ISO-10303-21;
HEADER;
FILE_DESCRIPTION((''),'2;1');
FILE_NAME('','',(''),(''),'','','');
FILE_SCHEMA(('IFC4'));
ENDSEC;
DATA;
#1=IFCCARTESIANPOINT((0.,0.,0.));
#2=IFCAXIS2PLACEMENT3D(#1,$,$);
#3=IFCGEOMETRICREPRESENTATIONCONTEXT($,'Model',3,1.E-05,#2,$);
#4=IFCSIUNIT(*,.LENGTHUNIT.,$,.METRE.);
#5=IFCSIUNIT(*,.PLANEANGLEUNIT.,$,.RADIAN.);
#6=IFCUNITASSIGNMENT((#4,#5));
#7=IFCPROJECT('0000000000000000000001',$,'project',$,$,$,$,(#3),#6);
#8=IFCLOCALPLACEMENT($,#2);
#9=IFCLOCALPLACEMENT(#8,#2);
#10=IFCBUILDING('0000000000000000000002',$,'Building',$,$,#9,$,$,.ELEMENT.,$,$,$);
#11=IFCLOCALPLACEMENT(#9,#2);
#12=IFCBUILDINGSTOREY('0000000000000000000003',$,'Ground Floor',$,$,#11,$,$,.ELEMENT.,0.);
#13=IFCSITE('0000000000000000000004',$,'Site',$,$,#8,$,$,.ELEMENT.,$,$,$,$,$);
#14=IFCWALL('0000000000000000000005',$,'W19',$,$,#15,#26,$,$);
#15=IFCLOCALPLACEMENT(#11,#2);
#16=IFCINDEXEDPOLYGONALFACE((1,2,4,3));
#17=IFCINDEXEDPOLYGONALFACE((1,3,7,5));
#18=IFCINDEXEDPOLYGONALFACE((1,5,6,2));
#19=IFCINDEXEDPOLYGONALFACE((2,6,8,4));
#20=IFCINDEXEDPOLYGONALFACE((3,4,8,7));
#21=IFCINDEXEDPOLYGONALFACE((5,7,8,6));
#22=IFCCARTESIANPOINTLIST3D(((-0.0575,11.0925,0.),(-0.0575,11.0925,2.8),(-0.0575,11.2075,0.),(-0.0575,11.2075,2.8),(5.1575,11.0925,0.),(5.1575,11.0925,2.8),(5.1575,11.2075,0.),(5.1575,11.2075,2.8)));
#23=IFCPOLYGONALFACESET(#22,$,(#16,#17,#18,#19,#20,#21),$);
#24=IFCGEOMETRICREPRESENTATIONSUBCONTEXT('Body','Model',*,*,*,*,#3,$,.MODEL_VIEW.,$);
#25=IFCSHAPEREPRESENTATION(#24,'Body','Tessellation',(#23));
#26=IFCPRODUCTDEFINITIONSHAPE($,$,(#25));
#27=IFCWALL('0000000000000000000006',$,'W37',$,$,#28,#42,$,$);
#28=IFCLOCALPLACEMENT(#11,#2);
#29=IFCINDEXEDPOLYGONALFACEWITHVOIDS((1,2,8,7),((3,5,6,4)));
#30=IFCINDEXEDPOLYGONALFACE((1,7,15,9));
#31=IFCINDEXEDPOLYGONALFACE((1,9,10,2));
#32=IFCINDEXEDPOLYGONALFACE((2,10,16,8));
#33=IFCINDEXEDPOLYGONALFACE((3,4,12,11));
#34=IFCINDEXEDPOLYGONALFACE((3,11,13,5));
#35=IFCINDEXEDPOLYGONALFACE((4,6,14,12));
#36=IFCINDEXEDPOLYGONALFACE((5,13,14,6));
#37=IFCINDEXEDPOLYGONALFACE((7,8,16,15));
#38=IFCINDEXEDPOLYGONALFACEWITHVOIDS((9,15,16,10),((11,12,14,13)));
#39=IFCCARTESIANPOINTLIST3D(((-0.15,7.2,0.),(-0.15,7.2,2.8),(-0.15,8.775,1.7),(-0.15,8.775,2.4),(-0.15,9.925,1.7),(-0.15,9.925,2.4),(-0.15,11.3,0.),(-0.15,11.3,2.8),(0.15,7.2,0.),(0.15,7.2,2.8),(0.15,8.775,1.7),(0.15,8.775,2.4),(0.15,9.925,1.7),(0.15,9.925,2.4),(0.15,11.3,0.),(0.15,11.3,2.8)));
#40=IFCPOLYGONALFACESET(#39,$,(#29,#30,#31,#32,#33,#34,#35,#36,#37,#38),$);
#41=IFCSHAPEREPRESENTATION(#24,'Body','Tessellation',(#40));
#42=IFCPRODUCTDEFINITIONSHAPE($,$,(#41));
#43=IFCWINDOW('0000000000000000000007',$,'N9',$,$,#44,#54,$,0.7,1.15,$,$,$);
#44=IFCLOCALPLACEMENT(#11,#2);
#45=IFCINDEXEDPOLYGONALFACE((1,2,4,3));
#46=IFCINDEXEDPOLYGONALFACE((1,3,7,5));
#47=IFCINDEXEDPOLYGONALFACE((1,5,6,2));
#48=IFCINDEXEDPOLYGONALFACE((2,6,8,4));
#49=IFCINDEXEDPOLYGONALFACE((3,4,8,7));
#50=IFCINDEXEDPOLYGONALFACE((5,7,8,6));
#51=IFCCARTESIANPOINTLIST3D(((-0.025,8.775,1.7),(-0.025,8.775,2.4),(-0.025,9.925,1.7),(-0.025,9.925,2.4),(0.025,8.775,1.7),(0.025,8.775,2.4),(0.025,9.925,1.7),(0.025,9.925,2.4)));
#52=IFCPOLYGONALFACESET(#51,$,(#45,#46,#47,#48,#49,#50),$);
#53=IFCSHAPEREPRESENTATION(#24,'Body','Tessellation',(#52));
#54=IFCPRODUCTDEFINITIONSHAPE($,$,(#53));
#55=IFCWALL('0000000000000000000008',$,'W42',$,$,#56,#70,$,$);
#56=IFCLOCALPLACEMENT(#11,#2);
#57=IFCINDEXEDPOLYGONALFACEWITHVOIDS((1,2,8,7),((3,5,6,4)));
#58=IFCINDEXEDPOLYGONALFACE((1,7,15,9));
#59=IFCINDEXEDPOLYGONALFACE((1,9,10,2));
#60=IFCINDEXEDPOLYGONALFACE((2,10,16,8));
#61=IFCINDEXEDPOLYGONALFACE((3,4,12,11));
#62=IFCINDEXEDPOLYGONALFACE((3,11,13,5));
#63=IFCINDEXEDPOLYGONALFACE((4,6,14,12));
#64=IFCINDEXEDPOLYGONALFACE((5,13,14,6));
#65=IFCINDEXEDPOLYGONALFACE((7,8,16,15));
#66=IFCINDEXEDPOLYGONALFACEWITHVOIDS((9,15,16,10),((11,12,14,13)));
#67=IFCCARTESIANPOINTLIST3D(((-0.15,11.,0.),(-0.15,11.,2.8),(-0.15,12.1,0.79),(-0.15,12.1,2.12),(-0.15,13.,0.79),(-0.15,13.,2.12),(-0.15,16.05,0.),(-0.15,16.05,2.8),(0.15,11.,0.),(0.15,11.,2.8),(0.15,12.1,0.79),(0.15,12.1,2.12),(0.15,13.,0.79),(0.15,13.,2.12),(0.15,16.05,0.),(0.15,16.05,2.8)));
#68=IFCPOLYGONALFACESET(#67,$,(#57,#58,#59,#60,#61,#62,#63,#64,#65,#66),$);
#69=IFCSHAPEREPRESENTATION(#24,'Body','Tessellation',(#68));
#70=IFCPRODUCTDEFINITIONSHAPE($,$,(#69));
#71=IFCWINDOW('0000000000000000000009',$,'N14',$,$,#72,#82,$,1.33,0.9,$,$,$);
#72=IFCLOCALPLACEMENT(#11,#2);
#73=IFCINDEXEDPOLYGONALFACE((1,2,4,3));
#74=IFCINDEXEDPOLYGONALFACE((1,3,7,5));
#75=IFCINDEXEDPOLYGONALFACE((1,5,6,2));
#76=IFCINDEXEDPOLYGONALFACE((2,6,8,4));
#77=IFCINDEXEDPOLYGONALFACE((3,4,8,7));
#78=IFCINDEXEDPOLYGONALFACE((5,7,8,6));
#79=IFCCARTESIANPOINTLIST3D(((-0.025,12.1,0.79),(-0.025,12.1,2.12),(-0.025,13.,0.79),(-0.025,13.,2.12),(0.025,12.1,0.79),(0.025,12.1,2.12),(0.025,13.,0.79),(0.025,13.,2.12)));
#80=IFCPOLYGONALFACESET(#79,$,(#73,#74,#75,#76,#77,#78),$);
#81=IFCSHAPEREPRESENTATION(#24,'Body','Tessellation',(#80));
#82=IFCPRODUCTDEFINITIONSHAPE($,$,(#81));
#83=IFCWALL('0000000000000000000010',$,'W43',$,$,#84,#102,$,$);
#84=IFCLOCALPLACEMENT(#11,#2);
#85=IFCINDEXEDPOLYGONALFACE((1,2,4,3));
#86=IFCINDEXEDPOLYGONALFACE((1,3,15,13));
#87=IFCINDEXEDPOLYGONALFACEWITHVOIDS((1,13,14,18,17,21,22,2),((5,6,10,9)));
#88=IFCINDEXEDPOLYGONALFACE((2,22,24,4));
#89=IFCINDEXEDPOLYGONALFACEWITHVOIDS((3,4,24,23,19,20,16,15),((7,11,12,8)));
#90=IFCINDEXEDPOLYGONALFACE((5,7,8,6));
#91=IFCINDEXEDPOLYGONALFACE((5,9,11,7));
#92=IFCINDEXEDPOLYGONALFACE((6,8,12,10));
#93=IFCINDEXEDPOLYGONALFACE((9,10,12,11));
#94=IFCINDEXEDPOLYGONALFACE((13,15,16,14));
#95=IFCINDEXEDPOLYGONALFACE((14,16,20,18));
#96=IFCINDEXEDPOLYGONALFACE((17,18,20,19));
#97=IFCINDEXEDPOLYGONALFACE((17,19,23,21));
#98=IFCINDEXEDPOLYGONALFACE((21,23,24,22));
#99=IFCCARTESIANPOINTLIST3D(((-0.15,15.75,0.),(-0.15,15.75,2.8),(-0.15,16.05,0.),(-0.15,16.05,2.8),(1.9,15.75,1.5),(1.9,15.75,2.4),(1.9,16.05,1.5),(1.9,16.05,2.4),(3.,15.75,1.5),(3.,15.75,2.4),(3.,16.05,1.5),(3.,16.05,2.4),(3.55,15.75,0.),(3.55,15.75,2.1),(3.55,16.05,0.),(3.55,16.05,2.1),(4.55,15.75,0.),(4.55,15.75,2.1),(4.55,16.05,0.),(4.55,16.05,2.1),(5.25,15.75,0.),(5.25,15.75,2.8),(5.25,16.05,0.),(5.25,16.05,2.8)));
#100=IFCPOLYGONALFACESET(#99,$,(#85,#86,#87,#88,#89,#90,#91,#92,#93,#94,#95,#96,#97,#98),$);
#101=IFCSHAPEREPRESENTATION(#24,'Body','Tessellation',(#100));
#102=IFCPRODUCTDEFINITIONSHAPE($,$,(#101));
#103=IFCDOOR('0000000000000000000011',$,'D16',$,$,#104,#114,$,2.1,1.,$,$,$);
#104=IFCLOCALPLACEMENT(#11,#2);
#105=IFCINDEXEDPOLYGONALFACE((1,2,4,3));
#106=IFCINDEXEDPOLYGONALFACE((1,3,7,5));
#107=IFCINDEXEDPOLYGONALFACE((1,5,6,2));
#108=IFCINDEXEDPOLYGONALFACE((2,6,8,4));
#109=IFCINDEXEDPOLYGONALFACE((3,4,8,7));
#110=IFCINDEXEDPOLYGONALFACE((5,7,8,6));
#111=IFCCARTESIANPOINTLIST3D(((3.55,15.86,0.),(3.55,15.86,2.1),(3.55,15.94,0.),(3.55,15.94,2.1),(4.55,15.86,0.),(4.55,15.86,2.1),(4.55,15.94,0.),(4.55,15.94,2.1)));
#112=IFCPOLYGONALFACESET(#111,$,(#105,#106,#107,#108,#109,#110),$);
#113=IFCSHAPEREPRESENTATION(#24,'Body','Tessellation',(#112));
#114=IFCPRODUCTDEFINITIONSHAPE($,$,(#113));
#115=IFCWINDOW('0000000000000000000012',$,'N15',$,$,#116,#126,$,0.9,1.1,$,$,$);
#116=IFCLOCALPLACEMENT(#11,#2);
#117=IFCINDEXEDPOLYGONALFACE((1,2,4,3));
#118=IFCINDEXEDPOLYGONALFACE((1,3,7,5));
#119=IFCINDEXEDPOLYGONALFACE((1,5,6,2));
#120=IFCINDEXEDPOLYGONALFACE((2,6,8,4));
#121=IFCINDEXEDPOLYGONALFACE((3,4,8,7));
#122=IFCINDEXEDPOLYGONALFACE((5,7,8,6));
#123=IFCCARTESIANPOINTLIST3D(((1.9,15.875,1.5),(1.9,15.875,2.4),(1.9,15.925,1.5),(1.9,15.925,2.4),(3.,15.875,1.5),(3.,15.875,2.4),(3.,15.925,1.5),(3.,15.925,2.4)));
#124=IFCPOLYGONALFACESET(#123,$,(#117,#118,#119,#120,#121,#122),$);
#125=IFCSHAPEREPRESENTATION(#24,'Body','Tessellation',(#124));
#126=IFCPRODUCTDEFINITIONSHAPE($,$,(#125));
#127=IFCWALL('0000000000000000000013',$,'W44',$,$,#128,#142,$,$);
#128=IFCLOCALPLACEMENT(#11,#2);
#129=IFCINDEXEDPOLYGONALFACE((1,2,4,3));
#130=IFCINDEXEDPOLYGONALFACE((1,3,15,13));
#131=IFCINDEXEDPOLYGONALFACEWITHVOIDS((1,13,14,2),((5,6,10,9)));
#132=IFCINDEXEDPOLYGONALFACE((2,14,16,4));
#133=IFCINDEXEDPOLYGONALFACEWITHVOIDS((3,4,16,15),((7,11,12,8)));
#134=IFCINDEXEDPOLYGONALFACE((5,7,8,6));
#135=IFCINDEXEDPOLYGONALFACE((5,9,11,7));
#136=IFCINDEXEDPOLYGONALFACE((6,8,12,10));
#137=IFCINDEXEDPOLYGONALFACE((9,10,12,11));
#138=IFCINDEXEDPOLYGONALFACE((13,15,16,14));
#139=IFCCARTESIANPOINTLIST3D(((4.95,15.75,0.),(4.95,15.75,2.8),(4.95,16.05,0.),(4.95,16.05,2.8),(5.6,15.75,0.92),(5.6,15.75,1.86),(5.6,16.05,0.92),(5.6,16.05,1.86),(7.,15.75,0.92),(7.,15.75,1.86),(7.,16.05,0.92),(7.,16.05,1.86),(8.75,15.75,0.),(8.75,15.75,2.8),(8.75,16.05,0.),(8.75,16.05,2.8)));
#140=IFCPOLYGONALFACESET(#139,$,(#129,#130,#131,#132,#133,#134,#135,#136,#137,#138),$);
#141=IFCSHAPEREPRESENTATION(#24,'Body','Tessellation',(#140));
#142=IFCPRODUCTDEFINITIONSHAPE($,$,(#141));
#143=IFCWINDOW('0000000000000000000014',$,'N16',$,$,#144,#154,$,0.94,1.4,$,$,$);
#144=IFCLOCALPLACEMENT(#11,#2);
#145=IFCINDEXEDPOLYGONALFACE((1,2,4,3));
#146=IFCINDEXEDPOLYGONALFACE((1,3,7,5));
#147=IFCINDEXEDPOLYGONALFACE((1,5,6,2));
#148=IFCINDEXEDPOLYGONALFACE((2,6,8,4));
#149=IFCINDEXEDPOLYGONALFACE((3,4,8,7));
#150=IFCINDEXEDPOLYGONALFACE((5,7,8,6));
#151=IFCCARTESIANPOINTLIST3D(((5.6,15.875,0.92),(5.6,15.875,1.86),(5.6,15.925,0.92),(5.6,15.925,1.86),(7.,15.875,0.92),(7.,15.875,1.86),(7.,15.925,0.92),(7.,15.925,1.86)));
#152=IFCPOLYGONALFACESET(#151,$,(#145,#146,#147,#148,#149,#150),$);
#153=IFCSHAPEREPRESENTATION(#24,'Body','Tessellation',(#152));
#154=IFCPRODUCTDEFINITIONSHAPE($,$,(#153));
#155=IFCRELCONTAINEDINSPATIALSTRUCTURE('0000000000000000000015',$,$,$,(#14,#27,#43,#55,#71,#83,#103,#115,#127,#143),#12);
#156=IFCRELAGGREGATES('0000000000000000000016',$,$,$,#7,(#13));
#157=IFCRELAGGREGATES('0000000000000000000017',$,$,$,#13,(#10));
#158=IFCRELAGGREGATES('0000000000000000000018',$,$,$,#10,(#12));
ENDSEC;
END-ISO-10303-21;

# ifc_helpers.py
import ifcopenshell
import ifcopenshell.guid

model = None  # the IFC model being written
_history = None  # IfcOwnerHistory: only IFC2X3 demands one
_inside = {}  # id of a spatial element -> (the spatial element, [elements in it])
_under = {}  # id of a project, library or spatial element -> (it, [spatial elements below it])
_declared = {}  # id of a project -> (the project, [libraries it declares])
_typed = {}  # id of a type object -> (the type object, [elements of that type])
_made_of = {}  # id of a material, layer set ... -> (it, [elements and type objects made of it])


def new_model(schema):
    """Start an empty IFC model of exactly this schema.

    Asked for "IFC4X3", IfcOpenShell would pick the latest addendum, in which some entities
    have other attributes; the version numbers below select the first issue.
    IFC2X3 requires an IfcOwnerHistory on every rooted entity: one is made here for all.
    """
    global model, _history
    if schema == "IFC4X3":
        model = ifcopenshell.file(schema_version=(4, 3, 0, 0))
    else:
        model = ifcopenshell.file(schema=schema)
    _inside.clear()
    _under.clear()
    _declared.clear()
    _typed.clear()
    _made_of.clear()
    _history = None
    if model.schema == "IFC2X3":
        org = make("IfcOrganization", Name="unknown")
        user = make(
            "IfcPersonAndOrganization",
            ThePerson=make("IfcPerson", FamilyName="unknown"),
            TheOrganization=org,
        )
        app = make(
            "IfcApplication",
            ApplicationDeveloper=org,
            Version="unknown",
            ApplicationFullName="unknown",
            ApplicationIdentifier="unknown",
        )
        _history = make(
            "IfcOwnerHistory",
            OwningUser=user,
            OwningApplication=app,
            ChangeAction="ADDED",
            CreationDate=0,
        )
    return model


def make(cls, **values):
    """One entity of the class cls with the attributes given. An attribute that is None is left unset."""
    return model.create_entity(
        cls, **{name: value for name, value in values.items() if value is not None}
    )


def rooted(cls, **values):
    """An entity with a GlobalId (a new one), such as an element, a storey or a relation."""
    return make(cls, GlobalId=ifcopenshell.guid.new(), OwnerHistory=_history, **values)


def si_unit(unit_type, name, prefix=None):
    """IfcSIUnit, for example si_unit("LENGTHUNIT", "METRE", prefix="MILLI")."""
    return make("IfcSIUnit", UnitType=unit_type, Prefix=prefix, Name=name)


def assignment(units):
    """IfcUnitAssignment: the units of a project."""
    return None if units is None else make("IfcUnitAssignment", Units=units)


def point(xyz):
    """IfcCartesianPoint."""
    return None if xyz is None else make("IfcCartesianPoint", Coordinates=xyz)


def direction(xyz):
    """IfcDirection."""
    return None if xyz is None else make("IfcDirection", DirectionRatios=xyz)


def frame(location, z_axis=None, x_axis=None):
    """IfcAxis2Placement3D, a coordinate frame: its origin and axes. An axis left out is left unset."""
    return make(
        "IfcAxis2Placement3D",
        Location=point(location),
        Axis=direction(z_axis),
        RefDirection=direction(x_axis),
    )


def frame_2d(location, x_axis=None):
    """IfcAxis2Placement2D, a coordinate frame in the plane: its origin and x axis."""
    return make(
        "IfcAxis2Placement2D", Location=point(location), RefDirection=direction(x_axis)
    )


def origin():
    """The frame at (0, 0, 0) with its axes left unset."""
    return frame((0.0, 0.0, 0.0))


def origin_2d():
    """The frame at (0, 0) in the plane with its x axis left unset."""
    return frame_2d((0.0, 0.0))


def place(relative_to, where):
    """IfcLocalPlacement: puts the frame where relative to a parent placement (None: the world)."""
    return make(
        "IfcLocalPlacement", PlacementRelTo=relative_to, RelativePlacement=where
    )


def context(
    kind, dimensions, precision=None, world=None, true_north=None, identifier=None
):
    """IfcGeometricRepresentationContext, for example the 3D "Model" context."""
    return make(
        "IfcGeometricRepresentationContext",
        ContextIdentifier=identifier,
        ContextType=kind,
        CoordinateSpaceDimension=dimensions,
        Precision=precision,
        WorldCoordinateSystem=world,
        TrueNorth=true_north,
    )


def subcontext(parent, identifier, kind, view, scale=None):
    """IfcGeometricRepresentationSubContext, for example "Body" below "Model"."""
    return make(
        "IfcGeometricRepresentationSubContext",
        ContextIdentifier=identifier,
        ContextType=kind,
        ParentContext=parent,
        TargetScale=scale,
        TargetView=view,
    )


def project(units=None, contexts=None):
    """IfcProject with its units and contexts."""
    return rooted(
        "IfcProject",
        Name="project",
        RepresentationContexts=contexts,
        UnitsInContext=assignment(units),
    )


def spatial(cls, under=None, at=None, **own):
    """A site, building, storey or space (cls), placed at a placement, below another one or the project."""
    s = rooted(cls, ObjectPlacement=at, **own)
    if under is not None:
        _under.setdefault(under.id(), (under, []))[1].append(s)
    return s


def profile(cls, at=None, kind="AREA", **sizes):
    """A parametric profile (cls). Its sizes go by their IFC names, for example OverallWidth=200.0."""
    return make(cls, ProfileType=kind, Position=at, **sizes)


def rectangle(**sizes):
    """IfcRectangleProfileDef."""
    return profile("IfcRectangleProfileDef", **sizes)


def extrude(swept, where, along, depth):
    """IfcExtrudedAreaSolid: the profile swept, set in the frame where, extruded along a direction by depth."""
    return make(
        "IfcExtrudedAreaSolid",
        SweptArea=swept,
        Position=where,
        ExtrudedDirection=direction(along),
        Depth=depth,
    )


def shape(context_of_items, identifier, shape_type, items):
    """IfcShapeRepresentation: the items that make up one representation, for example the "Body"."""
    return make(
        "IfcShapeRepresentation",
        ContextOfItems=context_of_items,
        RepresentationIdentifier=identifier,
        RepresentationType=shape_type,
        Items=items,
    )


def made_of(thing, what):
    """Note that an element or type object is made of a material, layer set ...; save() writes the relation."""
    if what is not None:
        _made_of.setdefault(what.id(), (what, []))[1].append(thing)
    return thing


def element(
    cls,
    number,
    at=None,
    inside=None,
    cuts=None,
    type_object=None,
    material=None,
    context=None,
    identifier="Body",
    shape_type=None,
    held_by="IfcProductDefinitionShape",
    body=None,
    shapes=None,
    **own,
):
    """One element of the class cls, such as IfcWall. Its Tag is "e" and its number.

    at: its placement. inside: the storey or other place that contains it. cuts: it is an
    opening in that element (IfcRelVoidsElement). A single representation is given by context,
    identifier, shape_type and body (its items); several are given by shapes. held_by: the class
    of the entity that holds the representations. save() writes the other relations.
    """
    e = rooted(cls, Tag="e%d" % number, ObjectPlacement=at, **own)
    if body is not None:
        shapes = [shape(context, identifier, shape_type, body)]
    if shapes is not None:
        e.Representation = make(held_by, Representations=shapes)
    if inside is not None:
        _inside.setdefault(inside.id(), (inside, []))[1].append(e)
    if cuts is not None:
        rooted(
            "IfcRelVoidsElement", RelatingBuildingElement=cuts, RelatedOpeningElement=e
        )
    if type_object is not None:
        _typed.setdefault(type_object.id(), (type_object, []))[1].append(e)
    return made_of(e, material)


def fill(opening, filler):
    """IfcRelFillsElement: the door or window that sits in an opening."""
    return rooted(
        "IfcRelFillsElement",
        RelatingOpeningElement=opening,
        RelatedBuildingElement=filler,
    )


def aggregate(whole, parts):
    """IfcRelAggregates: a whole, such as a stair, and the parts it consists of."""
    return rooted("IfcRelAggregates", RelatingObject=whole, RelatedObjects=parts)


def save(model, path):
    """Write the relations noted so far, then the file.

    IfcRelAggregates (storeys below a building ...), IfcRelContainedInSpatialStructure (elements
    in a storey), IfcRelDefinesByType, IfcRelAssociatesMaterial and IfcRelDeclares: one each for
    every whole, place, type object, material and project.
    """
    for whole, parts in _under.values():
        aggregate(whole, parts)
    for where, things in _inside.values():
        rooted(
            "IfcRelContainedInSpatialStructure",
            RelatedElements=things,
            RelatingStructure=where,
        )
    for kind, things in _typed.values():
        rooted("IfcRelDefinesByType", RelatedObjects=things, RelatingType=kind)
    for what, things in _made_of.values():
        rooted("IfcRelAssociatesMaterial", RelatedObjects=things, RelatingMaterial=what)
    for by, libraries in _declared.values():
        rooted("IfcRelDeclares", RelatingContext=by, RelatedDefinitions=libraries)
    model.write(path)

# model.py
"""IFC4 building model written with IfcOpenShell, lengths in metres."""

from ifc_helpers import new_model, si_unit, frame, frame_2d, origin, origin_2d, place, context, subcontext, project, spatial, rectangle, extrude, element, fill, save


model = new_model("IFC4")

# Units and contexts
model_context = context("Model", 3, precision=1e-05, world=origin())
body_context = subcontext(model_context, "Body", "Model", "MODEL_VIEW")
ifc_project = project(units=[si_unit("LENGTHUNIT", "METRE"), si_unit("PLANEANGLEUNIT", "RADIAN")], contexts=[model_context])

# Site, building, storey
site_placement = place(None, origin())
site = spatial("IfcSite", under=ifc_project, at=site_placement, Name="Site", CompositionType="ELEMENT")
building_placement = place(site_placement, origin())
building = spatial("IfcBuilding", under=site, at=building_placement, Name="Building", CompositionType="ELEMENT")
storey_placement = place(building_placement, origin())
storey = spatial("IfcBuildingStorey", under=building, at=storey_placement, Name="Ground Floor", CompositionType="ELEMENT", Elevation=0.0)

# Wall
wall_1_placement = place(storey_placement, frame((0.0, 11.15, 0.0), x_axis=(1.0, 0.0, 0.0)))
element("IfcWall", 1, at=wall_1_placement, inside=storey, Name="W19", context=body_context, shape_type="SweptSolid", body=[
    extrude(rectangle(XDim=5.215, YDim=0.115, at=frame_2d((2.55, 0.0))), origin(), (0.0, 0.0, 1.0), 2.8),
])

# Walls, openings, windows
wall_2_placement = place(storey_placement, frame((0.0, 7.35, 0.0), x_axis=(0.0, 1.0, 0.0)))
wall_2 = element("IfcWall", 2, at=wall_2_placement, inside=storey, Name="W37", context=body_context, shape_type="SweptSolid", body=[
    extrude(rectangle(XDim=4.1, YDim=0.3, at=frame_2d((1.9, 0.0))), origin(), (0.0, 0.0, 1.0), 2.8),
])
opening_1_placement = place(wall_2_placement, frame((2.0, 0.0, 1.7)))
opening_1 = element("IfcOpeningElement", 3, at=opening_1_placement, cuts=wall_2, context=body_context, shape_type="SweptSolid", body=[
    extrude(rectangle(XDim=1.15, YDim=0.4, at=origin_2d()), origin(), (0.0, 0.0, 1.0), 0.7),
])
window_1_placement = place(opening_1_placement, origin())
window_1 = element("IfcWindow", 4, at=window_1_placement, inside=storey, Name="N9", OverallHeight=0.7, OverallWidth=1.15, context=body_context, shape_type="SweptSolid", body=[
    extrude(rectangle(XDim=1.15, YDim=0.05, at=origin_2d()), origin(), (0.0, 0.0, 1.0), 0.7),
])
fill(opening_1, window_1)
wall_3_placement = place(storey_placement, frame((0.0, 11.15, 0.0), x_axis=(0.0, 1.0, 0.0)))
wall_3 = element("IfcWall", 5, at=wall_3_placement, inside=storey, Name="W42", context=body_context, shape_type="SweptSolid", body=[
    extrude(rectangle(XDim=5.05, YDim=0.3, at=frame_2d((2.375, 0.0))), origin(), (0.0, 0.0, 1.0), 2.8),
])
opening_2_placement = place(wall_3_placement, frame((1.4, 0.0, 0.79)))
opening_2 = element("IfcOpeningElement", 6, at=opening_2_placement, cuts=wall_3, context=body_context, shape_type="SweptSolid", body=[
    extrude(rectangle(XDim=0.9, YDim=0.4, at=origin_2d()), origin(), (0.0, 0.0, 1.0), 1.33),
])
window_2_placement = place(opening_2_placement, origin())
window_2 = element("IfcWindow", 7, at=window_2_placement, inside=storey, Name="N14", OverallHeight=1.33, OverallWidth=0.9, context=body_context, shape_type="SweptSolid", body=[
    extrude(rectangle(XDim=0.9, YDim=0.05, at=origin_2d()), origin(), (0.0, 0.0, 1.0), 1.33),
])
fill(opening_2, window_2)

# Wall, openings, door, window
wall_4_placement = place(storey_placement, frame((0.0, 15.9, 0.0), x_axis=(1.0, 0.0, 0.0)))
wall_4 = element("IfcWall", 8, at=wall_4_placement, inside=storey, Name="W43", context=body_context, shape_type="SweptSolid", body=[
    extrude(rectangle(XDim=5.4, YDim=0.3, at=frame_2d((2.55, 0.0))), origin(), (0.0, 0.0, 1.0), 2.8),
])
opening_3_placement = place(wall_4_placement, frame((4.05, 0.0, 0.0)))
opening_3 = element("IfcOpeningElement", 9, at=opening_3_placement, cuts=wall_4, context=body_context, shape_type="SweptSolid", body=[
    extrude(rectangle(XDim=1.0, YDim=0.4, at=origin_2d()), origin(), (0.0, 0.0, 1.0), 2.1),
])
opening_4_placement = place(wall_4_placement, frame((2.45, 0.0, 1.5)))
opening_4 = element("IfcOpeningElement", 10, at=opening_4_placement, cuts=wall_4, context=body_context, shape_type="SweptSolid", body=[
    extrude(rectangle(XDim=1.1, YDim=0.4, at=origin_2d()), origin(), (0.0, 0.0, 1.0), 0.9),
])
door_1_placement = place(opening_3_placement, origin())
door_1 = element("IfcDoor", 11, at=door_1_placement, inside=storey, Name="D16", OverallHeight=2.1, OverallWidth=1.0, context=body_context, shape_type="SweptSolid", body=[
    extrude(rectangle(XDim=1.0, YDim=0.08, at=origin_2d()), origin(), (0.0, 0.0, 1.0), 2.1),
])
fill(opening_3, door_1)
window_3_placement = place(opening_4_placement, origin())
window_3 = element("IfcWindow", 12, at=window_3_placement, inside=storey, Name="N15", OverallHeight=0.9, OverallWidth=1.1, context=body_context, shape_type="SweptSolid", body=[
    extrude(rectangle(XDim=1.1, YDim=0.05, at=origin_2d()), origin(), (0.0, 0.0, 1.0), 0.9),
])
fill(opening_4, window_3)

# Wall, opening, window
wall_5_placement = place(storey_placement, frame((5.1, 15.9, 0.0), x_axis=(1.0, 0.0, 0.0)))
wall_5 = element("IfcWall", 13, at=wall_5_placement, inside=storey, Name="W44", context=body_context, shape_type="SweptSolid", body=[
    extrude(rectangle(XDim=3.8, YDim=0.3, at=frame_2d((1.75, 0.0))), origin(), (0.0, 0.0, 1.0), 2.8),
])
opening_5_placement = place(wall_5_placement, frame((1.2, 0.0, 0.92)))
opening_5 = element("IfcOpeningElement", 14, at=opening_5_placement, cuts=wall_5, context=body_context, shape_type="SweptSolid", body=[
    extrude(rectangle(XDim=1.4, YDim=0.4, at=origin_2d()), origin(), (0.0, 0.0, 1.0), 0.94),
])
window_4_placement = place(opening_5_placement, origin())
window_4 = element("IfcWindow", 15, at=window_4_placement, inside=storey, Name="N16", OverallHeight=0.94, OverallWidth=1.4, context=body_context, shape_type="SweptSolid", body=[
    extrude(rectangle(XDim=1.4, YDim=0.05, at=origin_2d()), origin(), (0.0, 0.0, 1.0), 0.94),
])
fill(opening_5, window_4)

save(model, "model.ifc")
